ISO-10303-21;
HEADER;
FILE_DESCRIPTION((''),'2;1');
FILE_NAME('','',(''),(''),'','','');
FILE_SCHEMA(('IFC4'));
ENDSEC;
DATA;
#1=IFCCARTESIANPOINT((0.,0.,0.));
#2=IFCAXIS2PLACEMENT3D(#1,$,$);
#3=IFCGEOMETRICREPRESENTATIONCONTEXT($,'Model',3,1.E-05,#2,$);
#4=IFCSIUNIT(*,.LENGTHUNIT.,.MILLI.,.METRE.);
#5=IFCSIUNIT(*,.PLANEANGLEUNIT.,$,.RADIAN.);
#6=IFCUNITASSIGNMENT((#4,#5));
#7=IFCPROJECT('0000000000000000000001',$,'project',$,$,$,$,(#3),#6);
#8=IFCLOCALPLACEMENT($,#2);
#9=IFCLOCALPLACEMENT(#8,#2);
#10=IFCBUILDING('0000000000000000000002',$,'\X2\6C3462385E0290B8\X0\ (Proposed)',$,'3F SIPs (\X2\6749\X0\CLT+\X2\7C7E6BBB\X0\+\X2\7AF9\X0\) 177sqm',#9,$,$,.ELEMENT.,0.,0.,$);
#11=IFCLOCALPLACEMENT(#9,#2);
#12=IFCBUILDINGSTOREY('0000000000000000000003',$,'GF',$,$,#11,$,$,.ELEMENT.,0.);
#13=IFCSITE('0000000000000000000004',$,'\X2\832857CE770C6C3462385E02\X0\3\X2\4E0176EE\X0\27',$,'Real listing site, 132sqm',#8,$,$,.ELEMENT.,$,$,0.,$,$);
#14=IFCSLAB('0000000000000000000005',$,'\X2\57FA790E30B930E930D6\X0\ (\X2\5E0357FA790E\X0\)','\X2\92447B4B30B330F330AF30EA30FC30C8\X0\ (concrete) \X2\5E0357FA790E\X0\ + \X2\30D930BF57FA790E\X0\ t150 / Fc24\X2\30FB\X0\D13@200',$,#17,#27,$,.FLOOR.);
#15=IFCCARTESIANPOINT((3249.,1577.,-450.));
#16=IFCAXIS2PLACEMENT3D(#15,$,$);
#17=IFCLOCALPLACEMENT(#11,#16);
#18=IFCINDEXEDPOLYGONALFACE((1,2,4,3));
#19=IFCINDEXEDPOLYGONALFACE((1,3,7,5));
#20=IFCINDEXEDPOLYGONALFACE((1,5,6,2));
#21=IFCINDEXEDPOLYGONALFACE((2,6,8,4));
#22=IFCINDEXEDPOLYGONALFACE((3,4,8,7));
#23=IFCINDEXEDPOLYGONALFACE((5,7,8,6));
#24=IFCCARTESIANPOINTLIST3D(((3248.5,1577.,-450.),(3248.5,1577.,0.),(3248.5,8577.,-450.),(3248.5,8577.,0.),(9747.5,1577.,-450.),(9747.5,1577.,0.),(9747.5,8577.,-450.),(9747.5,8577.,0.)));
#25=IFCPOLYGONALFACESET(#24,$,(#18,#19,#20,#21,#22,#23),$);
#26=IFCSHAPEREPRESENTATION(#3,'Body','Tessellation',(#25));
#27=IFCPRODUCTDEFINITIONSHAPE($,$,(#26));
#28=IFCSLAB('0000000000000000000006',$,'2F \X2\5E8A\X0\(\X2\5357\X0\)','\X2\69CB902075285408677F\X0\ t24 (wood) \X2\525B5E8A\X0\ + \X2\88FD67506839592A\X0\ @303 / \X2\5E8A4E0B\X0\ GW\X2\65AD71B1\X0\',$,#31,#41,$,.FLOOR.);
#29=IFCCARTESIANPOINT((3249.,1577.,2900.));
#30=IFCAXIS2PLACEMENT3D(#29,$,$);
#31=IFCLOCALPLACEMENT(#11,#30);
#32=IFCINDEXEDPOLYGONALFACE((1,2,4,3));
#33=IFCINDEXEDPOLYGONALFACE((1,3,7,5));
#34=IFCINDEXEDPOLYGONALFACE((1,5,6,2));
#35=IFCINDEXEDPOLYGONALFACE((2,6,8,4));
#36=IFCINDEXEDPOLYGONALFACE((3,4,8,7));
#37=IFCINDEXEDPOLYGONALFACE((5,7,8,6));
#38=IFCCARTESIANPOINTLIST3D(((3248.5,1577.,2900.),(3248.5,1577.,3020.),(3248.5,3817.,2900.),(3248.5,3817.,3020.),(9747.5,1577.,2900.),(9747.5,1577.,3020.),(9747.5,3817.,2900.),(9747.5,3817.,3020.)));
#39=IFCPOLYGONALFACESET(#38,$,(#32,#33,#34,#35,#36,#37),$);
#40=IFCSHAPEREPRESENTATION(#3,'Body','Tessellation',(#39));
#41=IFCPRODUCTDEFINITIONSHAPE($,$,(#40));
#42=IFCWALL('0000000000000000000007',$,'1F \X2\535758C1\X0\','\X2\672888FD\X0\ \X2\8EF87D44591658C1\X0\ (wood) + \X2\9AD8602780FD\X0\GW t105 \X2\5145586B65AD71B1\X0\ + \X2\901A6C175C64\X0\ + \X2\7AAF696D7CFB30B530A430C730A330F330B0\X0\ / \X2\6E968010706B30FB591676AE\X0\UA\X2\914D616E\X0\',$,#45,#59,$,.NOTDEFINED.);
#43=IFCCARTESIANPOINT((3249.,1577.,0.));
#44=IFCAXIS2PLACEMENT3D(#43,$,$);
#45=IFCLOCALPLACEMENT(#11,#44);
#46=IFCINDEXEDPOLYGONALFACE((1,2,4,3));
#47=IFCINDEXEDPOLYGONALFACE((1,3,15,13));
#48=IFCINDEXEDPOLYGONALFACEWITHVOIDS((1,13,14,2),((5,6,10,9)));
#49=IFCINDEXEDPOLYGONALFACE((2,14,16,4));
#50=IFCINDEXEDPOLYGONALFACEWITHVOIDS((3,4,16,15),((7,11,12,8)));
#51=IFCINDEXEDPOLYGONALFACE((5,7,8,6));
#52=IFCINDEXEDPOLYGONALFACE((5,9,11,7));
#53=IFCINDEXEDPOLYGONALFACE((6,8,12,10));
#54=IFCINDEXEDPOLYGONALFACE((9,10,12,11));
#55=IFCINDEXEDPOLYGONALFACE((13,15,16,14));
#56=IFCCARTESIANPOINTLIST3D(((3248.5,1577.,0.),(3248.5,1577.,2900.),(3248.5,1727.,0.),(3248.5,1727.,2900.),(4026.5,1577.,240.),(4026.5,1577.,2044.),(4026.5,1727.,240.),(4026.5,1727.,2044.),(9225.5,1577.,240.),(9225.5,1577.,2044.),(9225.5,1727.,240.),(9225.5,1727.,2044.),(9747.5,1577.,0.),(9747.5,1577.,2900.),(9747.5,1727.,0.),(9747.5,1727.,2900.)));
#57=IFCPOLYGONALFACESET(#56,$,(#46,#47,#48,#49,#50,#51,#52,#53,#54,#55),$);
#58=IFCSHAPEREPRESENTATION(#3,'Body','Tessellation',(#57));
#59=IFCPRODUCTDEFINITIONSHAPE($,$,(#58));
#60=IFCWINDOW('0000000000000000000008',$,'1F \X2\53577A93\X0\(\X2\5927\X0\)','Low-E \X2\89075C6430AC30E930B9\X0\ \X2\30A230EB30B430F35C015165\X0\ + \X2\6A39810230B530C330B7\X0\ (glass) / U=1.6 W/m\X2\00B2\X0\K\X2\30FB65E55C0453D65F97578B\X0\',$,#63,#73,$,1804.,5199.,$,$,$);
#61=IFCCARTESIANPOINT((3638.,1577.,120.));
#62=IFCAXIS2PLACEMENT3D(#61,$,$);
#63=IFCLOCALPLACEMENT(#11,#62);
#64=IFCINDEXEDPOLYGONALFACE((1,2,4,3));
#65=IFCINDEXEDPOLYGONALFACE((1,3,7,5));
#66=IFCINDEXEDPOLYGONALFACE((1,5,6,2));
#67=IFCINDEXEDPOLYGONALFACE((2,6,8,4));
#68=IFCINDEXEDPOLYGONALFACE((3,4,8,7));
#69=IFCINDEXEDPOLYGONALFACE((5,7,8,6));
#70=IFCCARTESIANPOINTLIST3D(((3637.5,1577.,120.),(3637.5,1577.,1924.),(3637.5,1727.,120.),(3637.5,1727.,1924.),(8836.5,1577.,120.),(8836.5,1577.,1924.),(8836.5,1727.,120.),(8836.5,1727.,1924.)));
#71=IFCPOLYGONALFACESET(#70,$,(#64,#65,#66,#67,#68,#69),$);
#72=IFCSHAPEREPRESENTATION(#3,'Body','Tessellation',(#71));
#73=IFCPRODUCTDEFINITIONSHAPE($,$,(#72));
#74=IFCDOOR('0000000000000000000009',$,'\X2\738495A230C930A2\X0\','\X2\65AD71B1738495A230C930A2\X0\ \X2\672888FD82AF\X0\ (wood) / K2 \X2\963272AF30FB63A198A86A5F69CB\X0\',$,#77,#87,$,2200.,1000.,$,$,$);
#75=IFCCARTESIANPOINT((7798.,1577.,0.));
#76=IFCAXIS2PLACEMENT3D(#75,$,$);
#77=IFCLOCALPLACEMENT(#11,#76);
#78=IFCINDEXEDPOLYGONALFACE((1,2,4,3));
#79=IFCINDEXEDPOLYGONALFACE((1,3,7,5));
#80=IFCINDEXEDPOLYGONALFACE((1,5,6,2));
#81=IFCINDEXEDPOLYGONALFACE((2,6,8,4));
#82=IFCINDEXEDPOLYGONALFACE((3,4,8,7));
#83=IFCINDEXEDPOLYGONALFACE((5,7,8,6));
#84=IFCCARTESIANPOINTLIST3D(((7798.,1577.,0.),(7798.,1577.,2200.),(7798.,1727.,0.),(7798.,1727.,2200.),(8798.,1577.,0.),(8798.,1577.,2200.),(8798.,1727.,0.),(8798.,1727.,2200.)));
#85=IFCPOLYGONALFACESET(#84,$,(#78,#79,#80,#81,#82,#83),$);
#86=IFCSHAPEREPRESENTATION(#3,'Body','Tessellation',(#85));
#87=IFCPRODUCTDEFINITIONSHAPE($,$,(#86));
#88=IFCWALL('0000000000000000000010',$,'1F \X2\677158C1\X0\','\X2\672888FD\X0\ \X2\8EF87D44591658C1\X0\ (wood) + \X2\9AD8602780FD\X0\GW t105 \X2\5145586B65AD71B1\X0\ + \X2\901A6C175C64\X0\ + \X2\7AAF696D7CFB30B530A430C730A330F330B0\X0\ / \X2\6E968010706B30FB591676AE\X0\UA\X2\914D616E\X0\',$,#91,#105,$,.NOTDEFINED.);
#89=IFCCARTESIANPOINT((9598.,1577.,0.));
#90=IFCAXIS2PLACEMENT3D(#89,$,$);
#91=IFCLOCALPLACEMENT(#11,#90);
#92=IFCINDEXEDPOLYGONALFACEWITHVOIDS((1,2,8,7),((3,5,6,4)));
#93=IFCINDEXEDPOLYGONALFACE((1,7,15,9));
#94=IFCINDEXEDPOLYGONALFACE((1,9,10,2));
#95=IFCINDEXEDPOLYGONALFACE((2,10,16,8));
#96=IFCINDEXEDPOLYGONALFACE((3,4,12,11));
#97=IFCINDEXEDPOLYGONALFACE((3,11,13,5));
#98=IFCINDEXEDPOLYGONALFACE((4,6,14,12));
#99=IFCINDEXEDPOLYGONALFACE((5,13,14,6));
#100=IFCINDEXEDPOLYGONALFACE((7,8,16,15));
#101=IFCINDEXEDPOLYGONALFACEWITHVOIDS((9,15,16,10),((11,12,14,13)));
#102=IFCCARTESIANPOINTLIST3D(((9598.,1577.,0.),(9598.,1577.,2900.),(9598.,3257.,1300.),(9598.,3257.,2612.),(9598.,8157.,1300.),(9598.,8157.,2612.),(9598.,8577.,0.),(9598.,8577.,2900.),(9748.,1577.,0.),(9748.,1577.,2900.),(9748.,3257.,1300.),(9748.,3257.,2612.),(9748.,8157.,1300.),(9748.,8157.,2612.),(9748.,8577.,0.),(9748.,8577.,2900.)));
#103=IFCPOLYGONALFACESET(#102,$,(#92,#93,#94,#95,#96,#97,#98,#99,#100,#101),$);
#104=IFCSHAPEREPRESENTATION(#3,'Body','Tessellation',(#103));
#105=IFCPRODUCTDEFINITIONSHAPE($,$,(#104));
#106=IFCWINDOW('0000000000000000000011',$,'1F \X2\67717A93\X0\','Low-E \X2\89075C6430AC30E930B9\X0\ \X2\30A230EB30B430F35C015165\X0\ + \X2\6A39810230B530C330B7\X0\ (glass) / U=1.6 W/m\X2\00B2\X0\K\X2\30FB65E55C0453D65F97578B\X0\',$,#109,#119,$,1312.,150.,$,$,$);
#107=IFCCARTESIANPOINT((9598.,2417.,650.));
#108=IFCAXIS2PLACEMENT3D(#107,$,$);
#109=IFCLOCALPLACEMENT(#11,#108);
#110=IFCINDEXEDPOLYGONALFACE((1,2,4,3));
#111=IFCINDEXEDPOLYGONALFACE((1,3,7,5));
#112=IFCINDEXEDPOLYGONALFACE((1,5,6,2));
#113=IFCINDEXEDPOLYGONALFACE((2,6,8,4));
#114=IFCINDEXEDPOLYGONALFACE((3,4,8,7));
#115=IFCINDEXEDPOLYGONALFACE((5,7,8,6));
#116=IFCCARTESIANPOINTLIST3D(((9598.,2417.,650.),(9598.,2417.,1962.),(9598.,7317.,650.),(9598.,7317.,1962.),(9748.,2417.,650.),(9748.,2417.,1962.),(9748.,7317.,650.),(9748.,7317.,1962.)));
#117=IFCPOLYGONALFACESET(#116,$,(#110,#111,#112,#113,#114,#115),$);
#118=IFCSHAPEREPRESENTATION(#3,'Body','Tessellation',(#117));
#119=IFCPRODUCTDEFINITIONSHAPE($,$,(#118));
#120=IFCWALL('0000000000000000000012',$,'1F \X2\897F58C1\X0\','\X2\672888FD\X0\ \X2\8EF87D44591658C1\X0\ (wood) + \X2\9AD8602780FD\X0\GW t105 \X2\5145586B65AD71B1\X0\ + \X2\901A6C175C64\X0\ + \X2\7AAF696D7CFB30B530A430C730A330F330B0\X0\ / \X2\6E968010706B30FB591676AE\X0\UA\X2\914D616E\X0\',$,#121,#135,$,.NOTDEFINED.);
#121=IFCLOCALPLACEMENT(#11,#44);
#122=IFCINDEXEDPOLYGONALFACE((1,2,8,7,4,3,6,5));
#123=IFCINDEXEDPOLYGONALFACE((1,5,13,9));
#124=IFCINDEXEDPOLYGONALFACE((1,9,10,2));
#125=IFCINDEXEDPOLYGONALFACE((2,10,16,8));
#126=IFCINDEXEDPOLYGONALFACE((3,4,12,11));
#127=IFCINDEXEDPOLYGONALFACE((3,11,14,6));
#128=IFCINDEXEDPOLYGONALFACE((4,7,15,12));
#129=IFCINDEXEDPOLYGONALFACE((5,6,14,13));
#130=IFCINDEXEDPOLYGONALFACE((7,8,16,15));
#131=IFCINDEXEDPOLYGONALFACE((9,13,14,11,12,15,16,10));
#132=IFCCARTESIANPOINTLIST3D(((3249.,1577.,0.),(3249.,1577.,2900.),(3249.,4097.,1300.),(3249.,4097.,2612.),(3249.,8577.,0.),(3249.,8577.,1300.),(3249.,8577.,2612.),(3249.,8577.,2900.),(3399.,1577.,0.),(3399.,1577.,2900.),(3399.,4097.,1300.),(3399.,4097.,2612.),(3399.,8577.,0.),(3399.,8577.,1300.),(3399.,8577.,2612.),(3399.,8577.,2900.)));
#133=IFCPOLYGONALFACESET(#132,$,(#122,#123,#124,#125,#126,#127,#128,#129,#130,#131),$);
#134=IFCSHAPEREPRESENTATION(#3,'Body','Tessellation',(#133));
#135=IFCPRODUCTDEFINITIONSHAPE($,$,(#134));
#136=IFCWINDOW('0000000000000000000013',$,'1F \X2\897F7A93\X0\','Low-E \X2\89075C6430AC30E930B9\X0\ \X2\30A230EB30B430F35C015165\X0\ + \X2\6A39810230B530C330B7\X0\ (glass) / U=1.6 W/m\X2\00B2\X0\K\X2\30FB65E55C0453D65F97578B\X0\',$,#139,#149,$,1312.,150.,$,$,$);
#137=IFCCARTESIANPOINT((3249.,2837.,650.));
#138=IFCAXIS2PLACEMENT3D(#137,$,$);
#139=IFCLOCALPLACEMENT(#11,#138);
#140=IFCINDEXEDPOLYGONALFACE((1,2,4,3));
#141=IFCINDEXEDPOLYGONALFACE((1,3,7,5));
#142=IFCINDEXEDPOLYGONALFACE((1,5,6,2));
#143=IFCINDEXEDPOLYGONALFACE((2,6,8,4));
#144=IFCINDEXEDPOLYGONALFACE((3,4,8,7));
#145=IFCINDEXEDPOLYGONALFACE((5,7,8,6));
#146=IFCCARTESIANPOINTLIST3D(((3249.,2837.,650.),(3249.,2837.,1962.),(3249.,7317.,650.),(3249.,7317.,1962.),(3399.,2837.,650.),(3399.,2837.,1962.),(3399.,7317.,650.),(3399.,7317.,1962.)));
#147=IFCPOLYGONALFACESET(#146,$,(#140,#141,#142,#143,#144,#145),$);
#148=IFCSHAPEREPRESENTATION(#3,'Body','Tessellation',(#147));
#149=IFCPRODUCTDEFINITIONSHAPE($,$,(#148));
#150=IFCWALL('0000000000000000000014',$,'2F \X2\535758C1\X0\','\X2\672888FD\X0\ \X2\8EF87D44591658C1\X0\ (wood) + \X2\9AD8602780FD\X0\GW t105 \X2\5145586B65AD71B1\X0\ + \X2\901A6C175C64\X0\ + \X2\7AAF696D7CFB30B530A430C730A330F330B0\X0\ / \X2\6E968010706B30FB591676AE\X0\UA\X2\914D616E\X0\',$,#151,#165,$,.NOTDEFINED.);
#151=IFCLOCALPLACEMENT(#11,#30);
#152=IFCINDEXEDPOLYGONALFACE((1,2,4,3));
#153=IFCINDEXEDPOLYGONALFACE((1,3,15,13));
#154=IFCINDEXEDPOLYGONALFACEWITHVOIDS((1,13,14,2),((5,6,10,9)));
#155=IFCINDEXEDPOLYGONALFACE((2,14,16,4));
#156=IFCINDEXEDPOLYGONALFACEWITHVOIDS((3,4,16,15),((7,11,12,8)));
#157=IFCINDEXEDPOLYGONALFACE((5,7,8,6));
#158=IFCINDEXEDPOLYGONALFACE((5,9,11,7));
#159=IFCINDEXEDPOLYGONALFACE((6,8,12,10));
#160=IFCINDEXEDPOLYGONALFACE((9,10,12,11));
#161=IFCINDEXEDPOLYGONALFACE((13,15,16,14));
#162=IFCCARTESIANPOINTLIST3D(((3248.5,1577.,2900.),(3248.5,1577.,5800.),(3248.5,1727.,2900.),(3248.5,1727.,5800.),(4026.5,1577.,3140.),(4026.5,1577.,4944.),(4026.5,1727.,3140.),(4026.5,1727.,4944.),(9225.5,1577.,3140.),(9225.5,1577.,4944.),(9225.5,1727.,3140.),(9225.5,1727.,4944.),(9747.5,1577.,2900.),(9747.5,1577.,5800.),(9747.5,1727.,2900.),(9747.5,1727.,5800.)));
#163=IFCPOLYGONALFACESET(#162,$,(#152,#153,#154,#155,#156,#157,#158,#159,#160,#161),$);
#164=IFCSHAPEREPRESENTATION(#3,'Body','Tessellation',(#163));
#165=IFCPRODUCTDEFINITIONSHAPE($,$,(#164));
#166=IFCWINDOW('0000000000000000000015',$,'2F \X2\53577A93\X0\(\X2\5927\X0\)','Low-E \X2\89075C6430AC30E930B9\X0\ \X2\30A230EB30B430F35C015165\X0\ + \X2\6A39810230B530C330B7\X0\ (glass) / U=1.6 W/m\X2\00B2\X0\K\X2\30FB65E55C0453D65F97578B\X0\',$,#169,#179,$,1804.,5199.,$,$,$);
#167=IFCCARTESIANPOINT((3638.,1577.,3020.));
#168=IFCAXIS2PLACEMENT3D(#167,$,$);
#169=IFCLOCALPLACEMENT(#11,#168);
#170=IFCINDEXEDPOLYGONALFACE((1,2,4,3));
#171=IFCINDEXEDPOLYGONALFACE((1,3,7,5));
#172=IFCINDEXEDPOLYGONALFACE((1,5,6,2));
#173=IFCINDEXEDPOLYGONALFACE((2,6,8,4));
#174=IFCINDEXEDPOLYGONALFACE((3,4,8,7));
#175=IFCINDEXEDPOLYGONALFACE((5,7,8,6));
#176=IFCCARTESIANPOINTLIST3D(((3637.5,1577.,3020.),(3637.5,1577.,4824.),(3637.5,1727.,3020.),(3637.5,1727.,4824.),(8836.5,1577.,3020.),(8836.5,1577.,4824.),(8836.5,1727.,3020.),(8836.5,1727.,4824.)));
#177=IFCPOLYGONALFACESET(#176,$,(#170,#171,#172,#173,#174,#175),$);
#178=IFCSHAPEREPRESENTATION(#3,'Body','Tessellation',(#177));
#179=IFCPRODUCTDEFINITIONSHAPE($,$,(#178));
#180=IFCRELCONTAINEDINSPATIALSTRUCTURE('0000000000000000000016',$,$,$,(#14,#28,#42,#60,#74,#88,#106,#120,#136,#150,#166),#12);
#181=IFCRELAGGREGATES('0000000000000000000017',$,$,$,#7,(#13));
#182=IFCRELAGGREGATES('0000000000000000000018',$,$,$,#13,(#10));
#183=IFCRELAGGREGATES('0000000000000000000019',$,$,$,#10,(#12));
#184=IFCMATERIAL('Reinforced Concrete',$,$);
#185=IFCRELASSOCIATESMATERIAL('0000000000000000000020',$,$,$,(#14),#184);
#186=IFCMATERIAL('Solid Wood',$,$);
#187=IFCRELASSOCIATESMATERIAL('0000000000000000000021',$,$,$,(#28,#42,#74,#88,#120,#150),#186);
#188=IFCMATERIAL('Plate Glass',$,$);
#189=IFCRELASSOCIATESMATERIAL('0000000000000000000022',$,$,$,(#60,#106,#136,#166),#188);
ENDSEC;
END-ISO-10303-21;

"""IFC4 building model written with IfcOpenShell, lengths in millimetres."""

from ifc_helpers import new_model, si_unit, frame, frame_2d, origin, place, context, project, spatial, rectangle, extrude, material, element, fill, save


model = new_model("IFC4")

# Units and contexts
model_context = context("Model", 3, precision=1e-05, world=origin())
ifc_project = project(units=[si_unit("LENGTHUNIT", "METRE", prefix="MILLI"), si_unit("PLANEANGLEUNIT", "RADIAN")], contexts=[model_context])

# Site, building, storey
site_placement = place(None, origin())
site = spatial("IfcSite", under=ifc_project, at=site_placement, Name="茨城県水戸市3丁目27", ObjectType="Real listing site, 132sqm", CompositionType="ELEMENT", RefElevation=0.0)
building_placement = place(site_placement, origin())
building = spatial("IfcBuilding", under=site, at=building_placement, Name="水戸市邸 (Proposed)", ObjectType="3F SIPs (杉CLT+籾殻+竹) 177sqm", CompositionType="ELEMENT", ElevationOfRefHeight=0.0, ElevationOfTerrain=0.0)
storey_placement = place(building_placement, origin())
storey = spatial("IfcBuildingStorey", under=building, at=storey_placement, Name="GF", CompositionType="ELEMENT", Elevation=0.0)

# Slabs
ifc_material_1 = material(Name="Reinforced Concrete")
slab_1_placement = place(storey_placement, frame((3249.0, 1577.0, -450.0)))
element("IfcSlab", 1, at=slab_1_placement, inside=storey, material=ifc_material_1, Name="基礎スラブ (布基礎)", Description="鉄筋コンクリート (concrete) 布基礎 + ベタ基礎 t150 / Fc24・D13@200", PredefinedType="FLOOR", context=model_context, shape_type="SweptSolid", body=[
    extrude(rectangle(XDim=6499.0, YDim=7000.0, at=frame_2d((3249.0, 3500.0))), frame((3249.0, 1577.0, -450.0)), (0.0, 0.0, 1.0), 450.0),
])
ifc_material_2 = material(Name="Solid Wood")
slab_2_placement = place(storey_placement, frame((3249.0, 1577.0, 2900.0)))
element("IfcSlab", 2, at=slab_2_placement, inside=storey, material=ifc_material_2, Name="2F 床(南)", Description="構造用合板 t24 (wood) 剛床 + 製材根太 @303 / 床下 GW断熱", PredefinedType="FLOOR", context=model_context, shape_type="SweptSolid", body=[
    extrude(rectangle(XDim=6499.0, YDim=2240.0, at=frame_2d((3249.0, 1120.0))), frame((3249.0, 1577.0, 2900.0)), (0.0, 0.0, 1.0), 120.0),
])

# Wall, openings, window, door
wall_1_placement = place(storey_placement, frame((3249.0, 1577.0, 0.0)))
wall_1 = element("IfcWall", 3, at=wall_1_placement, inside=storey, material=ifc_material_2, Name="1F 南壁", Description="木製 軸組外壁 (wood) + 高性能GW t105 充填断熱 + 通気層 + 窯業系サイディング / 準耐火・外皮UA配慮", PredefinedType="NOTDEFINED", context=model_context, shape_type="SweptSolid", body=[
    extrude(rectangle(XDim=6499.0, YDim=150.0, at=frame_2d((3249.0, 75.0))), frame((3249.0, 1577.0, 0.0)), (0.0, 0.0, 1.0), 2900.0),
])
opening_1_placement = place(storey_placement, frame((3638.0, 1577.0, 120.0)))
opening_1 = element("IfcOpeningElement", 4, at=opening_1_placement, cuts=wall_1, PredefinedType="NOTDEFINED", context=model_context, shape_type="SweptSolid", body=[
    extrude(rectangle(XDim=5199.0, YDim=150.0, at=frame_2d((2599.0, 75.0))), frame((3638.0, 1577.0, 120.0)), (0.0, 0.0, 1.0), 1804.0),
])
opening_2_placement = place(storey_placement, frame((7798.0, 1577.0, 0.0)))
opening_2 = element("IfcOpeningElement", 5, at=opening_2_placement, cuts=wall_1, PredefinedType="NOTDEFINED", context=model_context, shape_type="SweptSolid", body=[
    extrude(rectangle(XDim=1000.0, YDim=150.0, at=frame_2d((500.0, 75.0))), frame((7798.0, 1577.0, 0.0)), (0.0, 0.0, 1.0), 2200.0),
])
ifc_material_3 = material(Name="Plate Glass")
window_1_placement = place(storey_placement, frame((3638.0, 1577.0, 120.0)))
window_1 = element("IfcWindow", 6, at=window_1_placement, inside=storey, material=ifc_material_3, Name="1F 南窓(大)", Description="Low-E 複層ガラス アルゴン封入 + 樹脂サッシ (glass) / U=1.6 W/m²K・日射取得型", OverallHeight=1804.0, OverallWidth=5199.0, context=model_context, shape_type="SweptSolid", body=[
    extrude(rectangle(XDim=5199.0, YDim=150.0, at=frame_2d((2599.0, 75.0))), frame((3638.0, 1577.0, 120.0)), (0.0, 0.0, 1.0), 1804.0),
])
fill(opening_1, window_1)
door_placement = place(storey_placement, frame((7798.0, 1577.0, 0.0)))
door = element("IfcDoor", 7, at=door_placement, inside=storey, material=ifc_material_2, Name="玄関ドア", Description="断熱玄関ドア 木製芯 (wood) / K2 防犯・採風機構", OverallHeight=2200.0, OverallWidth=1000.0, context=model_context, shape_type="SweptSolid", body=[
    extrude(rectangle(XDim=1000.0, YDim=150.0, at=frame_2d((500.0, 75.0))), frame((7798.0, 1577.0, 0.0)), (0.0, 0.0, 1.0), 2200.0),
])
fill(opening_2, door)

# Walls, openings, windows
wall_2_placement = place(storey_placement, frame((9598.0, 1577.0, 0.0)))
wall_2 = element("IfcWall", 8, at=wall_2_placement, inside=storey, material=ifc_material_2, Name="1F 東壁", Description="木製 軸組外壁 (wood) + 高性能GW t105 充填断熱 + 通気層 + 窯業系サイディング / 準耐火・外皮UA配慮", PredefinedType="NOTDEFINED", context=model_context, shape_type="SweptSolid", body=[
    extrude(rectangle(XDim=150.0, YDim=7000.0, at=frame_2d((75.0, 3500.0))), frame((9598.0, 1577.0, 0.0)), (0.0, 0.0, 1.0), 2900.0),
])
opening_3_placement = place(storey_placement, frame((9598.0, 2417.0, 650.0)))
opening_3 = element("IfcOpeningElement", 9, at=opening_3_placement, cuts=wall_2, PredefinedType="NOTDEFINED", context=model_context, shape_type="SweptSolid", body=[
    extrude(rectangle(XDim=150.0, YDim=4900.0, at=frame_2d((75.0, 2450.0))), frame((9598.0, 2417.0, 650.0)), (0.0, 0.0, 1.0), 1312.0),
])
window_2_placement = place(storey_placement, frame((9598.0, 2417.0, 650.0)))
window_2 = element("IfcWindow", 10, at=window_2_placement, inside=storey, material=ifc_material_3, Name="1F 東窓", Description="Low-E 複層ガラス アルゴン封入 + 樹脂サッシ (glass) / U=1.6 W/m²K・日射取得型", OverallHeight=1312.0, OverallWidth=150.0, context=model_context, shape_type="SweptSolid", body=[
    extrude(rectangle(XDim=150.0, YDim=4900.0, at=frame_2d((75.0, 2450.0))), frame((9598.0, 2417.0, 650.0)), (0.0, 0.0, 1.0), 1312.0),
])
fill(opening_3, window_2)
wall_3_placement = place(storey_placement, frame((3249.0, 1577.0, 0.0)))
wall_3 = element("IfcWall", 11, at=wall_3_placement, inside=storey, material=ifc_material_2, Name="1F 西壁", Description="木製 軸組外壁 (wood) + 高性能GW t105 充填断熱 + 通気層 + 窯業系サイディング / 準耐火・外皮UA配慮", PredefinedType="NOTDEFINED", context=model_context, shape_type="SweptSolid", body=[
    extrude(rectangle(XDim=150.0, YDim=7000.0, at=frame_2d((75.0, 3500.0))), frame((3249.0, 1577.0, 0.0)), (0.0, 0.0, 1.0), 2900.0),
])
opening_4_placement = place(storey_placement, frame((3249.0, 2837.0, 650.0)))
opening_4 = element("IfcOpeningElement", 12, at=opening_4_placement, cuts=wall_3, PredefinedType="NOTDEFINED", context=model_context, shape_type="SweptSolid", body=[
    extrude(rectangle(XDim=150.0, YDim=4480.0, at=frame_2d((75.0, 2240.0))), frame((3249.0, 2837.0, 650.0)), (0.0, 0.0, 1.0), 1312.0),
])
window_3_placement = place(storey_placement, frame((3249.0, 2837.0, 650.0)))
window_3 = element("IfcWindow", 13, at=window_3_placement, inside=storey, material=ifc_material_3, Name="1F 西窓", Description="Low-E 複層ガラス アルゴン封入 + 樹脂サッシ (glass) / U=1.6 W/m²K・日射取得型", OverallHeight=1312.0, OverallWidth=150.0, context=model_context, shape_type="SweptSolid", body=[
    extrude(rectangle(XDim=150.0, YDim=4480.0, at=frame_2d((75.0, 2240.0))), frame((3249.0, 2837.0, 650.0)), (0.0, 0.0, 1.0), 1312.0),
])
fill(opening_4, window_3)
wall_4_placement = place(storey_placement, frame((3249.0, 1577.0, 2900.0)))
wall_4 = element("IfcWall", 14, at=wall_4_placement, inside=storey, material=ifc_material_2, Name="2F 南壁", Description="木製 軸組外壁 (wood) + 高性能GW t105 充填断熱 + 通気層 + 窯業系サイディング / 準耐火・外皮UA配慮", PredefinedType="NOTDEFINED", context=model_context, shape_type="SweptSolid", body=[
    extrude(rectangle(XDim=6499.0, YDim=150.0, at=frame_2d((3249.0, 75.0))), frame((3249.0, 1577.0, 2900.0)), (0.0, 0.0, 1.0), 2900.0),
])
opening_5_placement = place(storey_placement, frame((3638.0, 1577.0, 3020.0)))
opening_5 = element("IfcOpeningElement", 15, at=opening_5_placement, cuts=wall_4, PredefinedType="NOTDEFINED", context=model_context, shape_type="SweptSolid", body=[
    extrude(rectangle(XDim=5199.0, YDim=150.0, at=frame_2d((2599.0, 75.0))), frame((3638.0, 1577.0, 3020.0)), (0.0, 0.0, 1.0), 1804.0),
])
window_4_placement = place(storey_placement, frame((3638.0, 1577.0, 3020.0)))
window_4 = element("IfcWindow", 16, at=window_4_placement, inside=storey, material=ifc_material_3, Name="2F 南窓(大)", Description="Low-E 複層ガラス アルゴン封入 + 樹脂サッシ (glass) / U=1.6 W/m²K・日射取得型", OverallHeight=1804.0, OverallWidth=5199.0, context=model_context, shape_type="SweptSolid", body=[
    extrude(rectangle(XDim=5199.0, YDim=150.0, at=frame_2d((2599.0, 75.0))), frame((3638.0, 1577.0, 3020.0)), (0.0, 0.0, 1.0), 1804.0),
])
fill(opening_5, window_4)

save(model, "model.ifc")
